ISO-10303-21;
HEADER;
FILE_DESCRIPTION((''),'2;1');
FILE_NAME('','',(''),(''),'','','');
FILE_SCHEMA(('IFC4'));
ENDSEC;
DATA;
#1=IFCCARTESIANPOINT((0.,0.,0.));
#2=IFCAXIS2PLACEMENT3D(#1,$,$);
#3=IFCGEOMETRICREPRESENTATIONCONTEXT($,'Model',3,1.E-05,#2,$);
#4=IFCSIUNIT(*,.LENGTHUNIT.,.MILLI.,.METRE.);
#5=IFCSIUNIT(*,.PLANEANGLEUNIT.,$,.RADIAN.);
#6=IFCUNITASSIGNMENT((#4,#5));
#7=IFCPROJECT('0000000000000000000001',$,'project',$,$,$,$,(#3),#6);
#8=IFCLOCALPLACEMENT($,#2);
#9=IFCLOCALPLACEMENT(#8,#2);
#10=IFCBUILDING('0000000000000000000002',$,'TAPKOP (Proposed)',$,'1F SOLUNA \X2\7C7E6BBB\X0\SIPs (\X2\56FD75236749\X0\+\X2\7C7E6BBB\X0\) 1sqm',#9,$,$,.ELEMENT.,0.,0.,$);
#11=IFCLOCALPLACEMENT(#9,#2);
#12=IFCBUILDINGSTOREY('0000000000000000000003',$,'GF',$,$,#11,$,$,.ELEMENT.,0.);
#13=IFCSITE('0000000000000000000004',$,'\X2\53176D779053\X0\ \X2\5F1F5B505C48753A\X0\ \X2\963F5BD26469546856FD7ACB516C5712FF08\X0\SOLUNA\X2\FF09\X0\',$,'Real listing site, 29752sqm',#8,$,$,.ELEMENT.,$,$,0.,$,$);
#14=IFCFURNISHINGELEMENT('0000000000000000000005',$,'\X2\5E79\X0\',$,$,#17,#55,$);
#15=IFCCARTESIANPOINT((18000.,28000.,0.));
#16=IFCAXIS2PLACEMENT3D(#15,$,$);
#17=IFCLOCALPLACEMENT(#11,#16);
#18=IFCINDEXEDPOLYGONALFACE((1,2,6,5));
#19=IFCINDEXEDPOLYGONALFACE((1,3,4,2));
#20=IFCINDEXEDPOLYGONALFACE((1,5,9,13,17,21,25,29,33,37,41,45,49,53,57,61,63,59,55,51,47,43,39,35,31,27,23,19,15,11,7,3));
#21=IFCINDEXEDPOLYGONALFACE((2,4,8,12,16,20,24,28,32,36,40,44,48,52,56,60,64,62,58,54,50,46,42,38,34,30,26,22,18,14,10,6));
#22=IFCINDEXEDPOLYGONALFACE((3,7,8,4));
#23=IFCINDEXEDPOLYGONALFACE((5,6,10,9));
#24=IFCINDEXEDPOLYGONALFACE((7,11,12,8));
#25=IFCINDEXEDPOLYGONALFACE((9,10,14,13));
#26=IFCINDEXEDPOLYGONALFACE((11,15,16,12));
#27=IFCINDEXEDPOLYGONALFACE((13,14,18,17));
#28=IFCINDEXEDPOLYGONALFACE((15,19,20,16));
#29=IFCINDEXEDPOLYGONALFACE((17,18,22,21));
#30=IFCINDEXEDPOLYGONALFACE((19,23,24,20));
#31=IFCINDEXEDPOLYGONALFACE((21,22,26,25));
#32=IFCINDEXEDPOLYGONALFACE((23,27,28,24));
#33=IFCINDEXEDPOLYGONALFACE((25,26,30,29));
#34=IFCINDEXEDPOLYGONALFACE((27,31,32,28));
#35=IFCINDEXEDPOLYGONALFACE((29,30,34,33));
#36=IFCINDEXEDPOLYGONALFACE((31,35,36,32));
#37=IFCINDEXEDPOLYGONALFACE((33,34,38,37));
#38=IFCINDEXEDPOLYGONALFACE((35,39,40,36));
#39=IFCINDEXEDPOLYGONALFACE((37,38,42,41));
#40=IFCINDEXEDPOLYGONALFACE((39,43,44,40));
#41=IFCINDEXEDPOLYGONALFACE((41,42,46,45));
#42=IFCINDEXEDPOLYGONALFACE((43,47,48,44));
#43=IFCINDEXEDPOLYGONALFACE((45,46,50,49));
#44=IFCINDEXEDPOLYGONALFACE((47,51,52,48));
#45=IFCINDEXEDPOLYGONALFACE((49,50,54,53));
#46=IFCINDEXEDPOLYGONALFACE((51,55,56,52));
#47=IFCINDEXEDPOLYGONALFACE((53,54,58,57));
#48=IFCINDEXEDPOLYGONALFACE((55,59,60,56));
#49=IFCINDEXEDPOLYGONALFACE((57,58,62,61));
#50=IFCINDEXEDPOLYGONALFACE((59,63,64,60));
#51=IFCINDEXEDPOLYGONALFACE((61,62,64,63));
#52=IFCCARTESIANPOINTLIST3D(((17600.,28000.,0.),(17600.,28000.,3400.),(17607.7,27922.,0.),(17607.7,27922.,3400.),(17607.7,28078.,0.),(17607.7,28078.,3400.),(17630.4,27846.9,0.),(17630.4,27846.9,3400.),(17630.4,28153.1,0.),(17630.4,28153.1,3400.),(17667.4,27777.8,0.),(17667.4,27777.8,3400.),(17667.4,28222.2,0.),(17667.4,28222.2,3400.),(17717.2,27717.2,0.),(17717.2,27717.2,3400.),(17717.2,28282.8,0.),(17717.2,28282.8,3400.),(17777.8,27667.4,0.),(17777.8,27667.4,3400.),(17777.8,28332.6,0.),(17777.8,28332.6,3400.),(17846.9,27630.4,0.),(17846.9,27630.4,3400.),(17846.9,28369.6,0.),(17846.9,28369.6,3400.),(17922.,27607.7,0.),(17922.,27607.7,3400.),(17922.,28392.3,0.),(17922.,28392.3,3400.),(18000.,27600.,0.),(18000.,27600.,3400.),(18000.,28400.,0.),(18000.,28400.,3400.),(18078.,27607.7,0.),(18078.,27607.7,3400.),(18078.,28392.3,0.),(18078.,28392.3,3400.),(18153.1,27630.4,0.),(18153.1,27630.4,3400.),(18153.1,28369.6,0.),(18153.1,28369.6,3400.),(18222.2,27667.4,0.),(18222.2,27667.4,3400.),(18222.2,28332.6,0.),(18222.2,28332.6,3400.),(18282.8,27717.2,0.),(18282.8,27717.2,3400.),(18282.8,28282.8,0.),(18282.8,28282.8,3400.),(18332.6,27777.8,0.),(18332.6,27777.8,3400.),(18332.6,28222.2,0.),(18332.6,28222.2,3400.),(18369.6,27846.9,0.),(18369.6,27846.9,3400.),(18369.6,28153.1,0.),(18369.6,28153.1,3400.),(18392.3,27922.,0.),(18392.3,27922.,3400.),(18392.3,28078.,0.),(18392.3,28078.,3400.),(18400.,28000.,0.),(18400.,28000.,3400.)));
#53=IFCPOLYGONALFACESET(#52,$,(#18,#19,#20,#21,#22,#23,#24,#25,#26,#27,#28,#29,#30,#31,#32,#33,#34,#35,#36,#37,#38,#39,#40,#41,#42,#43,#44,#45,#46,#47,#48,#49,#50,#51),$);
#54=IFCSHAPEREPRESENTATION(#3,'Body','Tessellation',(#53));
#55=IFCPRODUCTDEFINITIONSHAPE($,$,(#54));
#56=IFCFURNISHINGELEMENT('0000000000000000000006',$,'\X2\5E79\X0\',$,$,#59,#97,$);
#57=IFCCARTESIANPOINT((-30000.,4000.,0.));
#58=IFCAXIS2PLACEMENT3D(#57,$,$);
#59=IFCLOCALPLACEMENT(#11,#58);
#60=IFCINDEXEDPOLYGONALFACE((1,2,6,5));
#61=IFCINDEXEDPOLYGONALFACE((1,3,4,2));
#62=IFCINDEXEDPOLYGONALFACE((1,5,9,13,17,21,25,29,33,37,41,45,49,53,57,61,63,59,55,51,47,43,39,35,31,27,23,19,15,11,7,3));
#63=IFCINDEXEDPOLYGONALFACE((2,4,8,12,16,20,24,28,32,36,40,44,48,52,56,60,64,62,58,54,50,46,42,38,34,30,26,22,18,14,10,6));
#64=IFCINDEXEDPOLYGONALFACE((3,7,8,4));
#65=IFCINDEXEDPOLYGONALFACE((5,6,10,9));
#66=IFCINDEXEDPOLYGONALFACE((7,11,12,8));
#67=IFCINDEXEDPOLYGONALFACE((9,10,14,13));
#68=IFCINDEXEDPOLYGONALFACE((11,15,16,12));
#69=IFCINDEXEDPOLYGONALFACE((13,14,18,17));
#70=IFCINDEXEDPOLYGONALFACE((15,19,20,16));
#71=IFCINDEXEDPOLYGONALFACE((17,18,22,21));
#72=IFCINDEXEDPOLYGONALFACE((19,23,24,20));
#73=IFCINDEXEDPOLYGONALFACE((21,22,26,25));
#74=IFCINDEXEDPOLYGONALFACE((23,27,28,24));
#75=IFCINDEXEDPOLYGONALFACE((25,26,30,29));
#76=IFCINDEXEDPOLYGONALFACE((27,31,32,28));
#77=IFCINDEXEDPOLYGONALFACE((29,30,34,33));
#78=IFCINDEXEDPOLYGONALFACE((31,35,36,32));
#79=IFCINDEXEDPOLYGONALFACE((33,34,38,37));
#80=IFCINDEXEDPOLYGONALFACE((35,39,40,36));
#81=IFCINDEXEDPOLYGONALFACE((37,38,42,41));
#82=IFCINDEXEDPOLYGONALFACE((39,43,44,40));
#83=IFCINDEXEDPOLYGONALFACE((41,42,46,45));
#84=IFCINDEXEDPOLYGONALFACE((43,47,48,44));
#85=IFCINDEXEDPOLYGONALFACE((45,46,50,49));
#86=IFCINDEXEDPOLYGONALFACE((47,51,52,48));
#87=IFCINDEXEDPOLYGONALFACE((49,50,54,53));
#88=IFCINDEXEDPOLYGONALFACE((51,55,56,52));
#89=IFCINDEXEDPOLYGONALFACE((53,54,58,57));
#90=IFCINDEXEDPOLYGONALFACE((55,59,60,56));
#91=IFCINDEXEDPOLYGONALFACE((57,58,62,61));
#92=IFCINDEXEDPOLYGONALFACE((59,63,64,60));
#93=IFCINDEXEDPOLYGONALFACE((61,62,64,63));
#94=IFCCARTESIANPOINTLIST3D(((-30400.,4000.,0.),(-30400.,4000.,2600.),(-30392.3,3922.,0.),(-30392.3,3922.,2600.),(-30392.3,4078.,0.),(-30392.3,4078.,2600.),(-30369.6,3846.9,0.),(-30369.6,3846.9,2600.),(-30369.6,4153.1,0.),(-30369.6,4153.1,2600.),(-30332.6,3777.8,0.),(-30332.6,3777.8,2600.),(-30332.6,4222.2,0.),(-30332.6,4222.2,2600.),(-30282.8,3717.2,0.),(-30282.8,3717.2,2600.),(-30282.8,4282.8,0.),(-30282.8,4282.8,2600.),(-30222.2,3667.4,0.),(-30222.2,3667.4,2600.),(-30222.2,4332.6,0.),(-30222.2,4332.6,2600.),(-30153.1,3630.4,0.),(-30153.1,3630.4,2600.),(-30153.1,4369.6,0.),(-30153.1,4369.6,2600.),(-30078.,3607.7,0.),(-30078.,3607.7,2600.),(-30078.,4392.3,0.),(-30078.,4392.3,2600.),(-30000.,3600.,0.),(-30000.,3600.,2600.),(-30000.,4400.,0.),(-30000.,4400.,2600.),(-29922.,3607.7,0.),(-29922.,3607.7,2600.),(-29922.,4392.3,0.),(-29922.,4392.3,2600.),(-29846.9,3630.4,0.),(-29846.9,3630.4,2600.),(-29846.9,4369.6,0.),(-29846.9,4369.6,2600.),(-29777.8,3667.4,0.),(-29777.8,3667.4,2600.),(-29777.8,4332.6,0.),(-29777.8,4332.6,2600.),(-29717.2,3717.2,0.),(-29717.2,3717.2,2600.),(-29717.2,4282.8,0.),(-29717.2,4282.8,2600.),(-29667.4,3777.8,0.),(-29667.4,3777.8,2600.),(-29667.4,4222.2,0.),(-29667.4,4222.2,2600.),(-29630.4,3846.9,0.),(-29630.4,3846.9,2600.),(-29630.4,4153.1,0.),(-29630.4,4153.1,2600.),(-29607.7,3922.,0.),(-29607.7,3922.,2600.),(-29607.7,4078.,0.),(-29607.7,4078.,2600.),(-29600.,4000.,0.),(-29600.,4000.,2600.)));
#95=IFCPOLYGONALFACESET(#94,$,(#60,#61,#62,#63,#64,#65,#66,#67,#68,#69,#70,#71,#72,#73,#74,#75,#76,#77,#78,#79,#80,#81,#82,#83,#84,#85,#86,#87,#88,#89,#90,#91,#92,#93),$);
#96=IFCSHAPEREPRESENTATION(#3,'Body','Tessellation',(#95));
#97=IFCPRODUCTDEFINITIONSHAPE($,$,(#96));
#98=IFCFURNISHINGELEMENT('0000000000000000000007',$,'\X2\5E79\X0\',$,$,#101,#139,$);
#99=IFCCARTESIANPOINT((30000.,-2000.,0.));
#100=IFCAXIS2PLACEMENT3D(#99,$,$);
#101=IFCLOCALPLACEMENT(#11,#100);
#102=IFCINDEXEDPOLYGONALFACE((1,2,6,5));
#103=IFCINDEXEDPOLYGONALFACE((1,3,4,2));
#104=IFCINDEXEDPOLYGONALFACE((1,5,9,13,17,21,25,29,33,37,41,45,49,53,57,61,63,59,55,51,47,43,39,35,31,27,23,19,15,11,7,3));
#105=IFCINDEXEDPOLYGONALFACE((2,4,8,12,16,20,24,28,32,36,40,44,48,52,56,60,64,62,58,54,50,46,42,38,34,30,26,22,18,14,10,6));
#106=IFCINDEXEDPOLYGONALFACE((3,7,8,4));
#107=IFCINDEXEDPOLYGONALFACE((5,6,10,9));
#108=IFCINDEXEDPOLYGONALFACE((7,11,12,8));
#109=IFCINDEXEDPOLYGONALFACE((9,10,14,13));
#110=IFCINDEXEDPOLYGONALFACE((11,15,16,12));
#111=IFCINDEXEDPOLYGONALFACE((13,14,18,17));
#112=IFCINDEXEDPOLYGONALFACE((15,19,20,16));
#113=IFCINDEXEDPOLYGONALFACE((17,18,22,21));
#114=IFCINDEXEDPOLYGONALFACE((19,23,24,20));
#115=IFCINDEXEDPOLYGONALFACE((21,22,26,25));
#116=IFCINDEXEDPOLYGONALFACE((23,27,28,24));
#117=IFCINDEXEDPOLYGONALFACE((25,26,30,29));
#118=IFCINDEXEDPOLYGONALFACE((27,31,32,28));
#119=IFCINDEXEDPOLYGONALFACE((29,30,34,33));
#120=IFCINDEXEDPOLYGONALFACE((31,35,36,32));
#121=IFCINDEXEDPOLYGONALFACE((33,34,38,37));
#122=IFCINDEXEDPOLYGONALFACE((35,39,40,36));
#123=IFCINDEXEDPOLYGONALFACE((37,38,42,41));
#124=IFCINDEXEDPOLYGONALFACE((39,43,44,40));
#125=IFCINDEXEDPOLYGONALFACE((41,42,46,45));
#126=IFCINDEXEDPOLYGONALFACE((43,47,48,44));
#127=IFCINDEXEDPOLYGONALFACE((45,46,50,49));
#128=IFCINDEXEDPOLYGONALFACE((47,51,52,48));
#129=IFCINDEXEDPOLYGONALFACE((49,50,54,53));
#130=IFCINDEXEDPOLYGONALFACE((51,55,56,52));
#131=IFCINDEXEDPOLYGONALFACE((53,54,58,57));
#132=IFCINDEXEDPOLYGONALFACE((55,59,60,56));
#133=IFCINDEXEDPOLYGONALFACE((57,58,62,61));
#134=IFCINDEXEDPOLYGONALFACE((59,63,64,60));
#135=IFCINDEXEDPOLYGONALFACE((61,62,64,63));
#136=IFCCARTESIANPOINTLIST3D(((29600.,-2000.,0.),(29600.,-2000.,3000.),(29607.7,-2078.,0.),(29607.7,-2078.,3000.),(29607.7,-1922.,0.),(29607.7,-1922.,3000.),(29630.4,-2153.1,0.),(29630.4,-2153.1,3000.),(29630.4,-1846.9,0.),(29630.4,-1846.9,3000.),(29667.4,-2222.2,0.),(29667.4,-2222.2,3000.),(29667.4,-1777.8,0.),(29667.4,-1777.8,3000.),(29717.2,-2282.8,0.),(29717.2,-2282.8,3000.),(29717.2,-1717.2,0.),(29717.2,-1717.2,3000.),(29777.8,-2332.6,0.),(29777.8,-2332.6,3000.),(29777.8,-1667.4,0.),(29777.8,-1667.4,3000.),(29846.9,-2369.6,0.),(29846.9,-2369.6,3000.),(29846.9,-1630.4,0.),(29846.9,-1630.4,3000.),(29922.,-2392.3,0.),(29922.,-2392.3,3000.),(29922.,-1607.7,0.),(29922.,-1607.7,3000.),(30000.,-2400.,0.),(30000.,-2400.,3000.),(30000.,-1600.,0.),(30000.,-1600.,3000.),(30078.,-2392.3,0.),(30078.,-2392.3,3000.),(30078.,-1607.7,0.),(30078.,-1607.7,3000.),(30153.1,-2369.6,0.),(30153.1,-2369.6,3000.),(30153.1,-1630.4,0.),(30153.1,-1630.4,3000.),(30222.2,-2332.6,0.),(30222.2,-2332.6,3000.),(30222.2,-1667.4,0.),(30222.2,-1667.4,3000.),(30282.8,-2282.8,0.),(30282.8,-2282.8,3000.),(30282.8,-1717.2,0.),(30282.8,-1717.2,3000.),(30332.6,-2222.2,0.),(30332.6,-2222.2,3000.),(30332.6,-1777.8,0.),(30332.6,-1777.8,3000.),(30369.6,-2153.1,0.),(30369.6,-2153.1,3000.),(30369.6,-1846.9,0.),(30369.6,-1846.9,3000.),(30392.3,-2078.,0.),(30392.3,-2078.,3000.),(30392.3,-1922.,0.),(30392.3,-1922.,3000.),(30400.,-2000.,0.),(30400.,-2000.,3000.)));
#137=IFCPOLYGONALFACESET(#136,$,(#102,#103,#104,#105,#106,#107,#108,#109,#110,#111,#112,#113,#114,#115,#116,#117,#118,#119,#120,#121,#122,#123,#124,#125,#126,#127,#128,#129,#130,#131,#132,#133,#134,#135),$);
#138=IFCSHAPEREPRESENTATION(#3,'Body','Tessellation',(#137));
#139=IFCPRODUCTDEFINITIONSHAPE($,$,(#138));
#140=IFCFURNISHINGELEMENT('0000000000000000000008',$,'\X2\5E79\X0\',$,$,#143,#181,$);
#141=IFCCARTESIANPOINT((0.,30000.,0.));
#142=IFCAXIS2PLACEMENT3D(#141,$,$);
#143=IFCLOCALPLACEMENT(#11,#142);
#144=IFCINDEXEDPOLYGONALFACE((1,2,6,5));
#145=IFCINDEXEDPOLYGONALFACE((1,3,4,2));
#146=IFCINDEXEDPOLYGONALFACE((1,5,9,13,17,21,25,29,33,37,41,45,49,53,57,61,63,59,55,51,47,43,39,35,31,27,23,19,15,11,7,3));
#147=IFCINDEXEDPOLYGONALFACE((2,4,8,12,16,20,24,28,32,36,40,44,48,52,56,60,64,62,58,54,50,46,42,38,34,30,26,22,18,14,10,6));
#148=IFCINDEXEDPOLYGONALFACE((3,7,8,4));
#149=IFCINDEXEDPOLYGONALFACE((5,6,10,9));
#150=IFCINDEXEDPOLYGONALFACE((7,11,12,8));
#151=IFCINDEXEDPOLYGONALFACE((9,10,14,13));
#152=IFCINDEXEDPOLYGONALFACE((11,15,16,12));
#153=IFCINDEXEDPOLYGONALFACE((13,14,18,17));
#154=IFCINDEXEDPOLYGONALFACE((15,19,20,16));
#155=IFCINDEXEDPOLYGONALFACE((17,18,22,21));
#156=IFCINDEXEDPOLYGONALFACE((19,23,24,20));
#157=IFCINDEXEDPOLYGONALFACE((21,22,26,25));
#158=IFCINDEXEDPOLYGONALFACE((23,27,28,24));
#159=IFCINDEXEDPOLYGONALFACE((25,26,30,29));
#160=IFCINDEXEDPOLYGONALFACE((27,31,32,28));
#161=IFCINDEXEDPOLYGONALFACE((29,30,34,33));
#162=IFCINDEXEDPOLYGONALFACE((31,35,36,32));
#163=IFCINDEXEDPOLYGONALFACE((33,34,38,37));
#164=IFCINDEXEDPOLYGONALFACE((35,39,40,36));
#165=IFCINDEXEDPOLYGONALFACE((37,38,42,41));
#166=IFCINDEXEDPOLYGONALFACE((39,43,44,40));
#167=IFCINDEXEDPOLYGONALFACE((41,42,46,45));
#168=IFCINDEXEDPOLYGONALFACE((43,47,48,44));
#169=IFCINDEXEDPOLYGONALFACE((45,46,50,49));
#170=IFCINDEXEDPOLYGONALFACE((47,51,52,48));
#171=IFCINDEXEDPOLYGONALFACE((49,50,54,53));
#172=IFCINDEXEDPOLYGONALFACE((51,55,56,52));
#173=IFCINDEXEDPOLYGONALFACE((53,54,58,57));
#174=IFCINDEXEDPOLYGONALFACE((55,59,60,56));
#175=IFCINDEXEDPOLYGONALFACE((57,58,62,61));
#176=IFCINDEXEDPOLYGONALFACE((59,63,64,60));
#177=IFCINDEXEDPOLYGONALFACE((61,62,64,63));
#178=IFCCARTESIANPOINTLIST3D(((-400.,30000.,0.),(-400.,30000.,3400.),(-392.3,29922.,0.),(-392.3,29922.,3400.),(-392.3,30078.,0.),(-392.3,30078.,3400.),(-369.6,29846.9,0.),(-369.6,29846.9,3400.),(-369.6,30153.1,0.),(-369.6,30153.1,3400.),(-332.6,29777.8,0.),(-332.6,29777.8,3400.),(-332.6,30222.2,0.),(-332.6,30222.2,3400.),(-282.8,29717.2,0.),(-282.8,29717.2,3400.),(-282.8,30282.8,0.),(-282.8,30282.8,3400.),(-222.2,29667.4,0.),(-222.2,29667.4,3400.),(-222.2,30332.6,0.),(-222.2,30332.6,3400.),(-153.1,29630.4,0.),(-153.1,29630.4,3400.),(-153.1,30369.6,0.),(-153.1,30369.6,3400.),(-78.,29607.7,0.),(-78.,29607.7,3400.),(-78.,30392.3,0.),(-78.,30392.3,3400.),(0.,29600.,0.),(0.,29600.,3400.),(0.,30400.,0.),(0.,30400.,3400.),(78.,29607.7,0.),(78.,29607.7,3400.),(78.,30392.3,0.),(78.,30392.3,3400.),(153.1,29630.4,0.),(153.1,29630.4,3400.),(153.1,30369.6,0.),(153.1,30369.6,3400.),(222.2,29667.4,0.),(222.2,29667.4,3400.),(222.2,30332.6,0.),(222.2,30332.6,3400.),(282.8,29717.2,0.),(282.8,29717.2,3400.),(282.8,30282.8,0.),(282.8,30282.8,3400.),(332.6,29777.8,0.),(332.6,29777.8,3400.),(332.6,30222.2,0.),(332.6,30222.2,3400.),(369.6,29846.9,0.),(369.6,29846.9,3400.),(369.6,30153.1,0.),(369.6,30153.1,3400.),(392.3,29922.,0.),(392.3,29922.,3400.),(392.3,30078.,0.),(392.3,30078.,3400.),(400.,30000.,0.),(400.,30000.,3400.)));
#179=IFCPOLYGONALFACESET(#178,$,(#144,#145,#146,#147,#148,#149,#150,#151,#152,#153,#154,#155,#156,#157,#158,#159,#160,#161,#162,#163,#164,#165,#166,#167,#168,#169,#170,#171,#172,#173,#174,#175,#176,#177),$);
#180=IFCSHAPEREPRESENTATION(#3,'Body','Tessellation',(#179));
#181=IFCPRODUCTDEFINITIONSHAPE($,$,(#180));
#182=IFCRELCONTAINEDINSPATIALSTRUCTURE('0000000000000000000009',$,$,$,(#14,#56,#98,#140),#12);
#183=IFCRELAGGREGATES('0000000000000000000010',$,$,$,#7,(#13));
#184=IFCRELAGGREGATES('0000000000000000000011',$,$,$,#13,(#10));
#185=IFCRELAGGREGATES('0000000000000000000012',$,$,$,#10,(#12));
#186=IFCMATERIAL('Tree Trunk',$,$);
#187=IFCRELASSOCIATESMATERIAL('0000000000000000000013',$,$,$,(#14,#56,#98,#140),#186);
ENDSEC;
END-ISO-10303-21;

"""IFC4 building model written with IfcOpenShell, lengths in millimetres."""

from ifc_helpers import new_model, si_unit, frame, origin, origin_2d, place, context, project, spatial, circle, extrude, material, element, save


model = new_model("IFC4")

# Units and contexts
model_context = context("Model", 3, precision=1e-05, world=origin())
ifc_project = project(units=[si_unit("LENGTHUNIT", "METRE", prefix="MILLI"), si_unit("PLANEANGLEUNIT", "RADIAN")], contexts=[model_context])

# Site, building, storey
site_placement = place(None, origin())
site = spatial("IfcSite", under=ifc_project, at=site_placement, Name="北海道 弟子屈町 阿寒摩周国立公園（SOLUNA）", ObjectType="Real listing site, 29752sqm", CompositionType="ELEMENT", RefElevation=0.0)
building_placement = place(site_placement, origin())
building = spatial("IfcBuilding", under=site, at=building_placement, Name="TAPKOP (Proposed)", ObjectType="1F SOLUNA 籾殻SIPs (国産杉+籾殻) 1sqm", CompositionType="ELEMENT", ElevationOfRefHeight=0.0, ElevationOfTerrain=0.0)
storey_placement = place(building_placement, origin())
storey = spatial("IfcBuildingStorey", under=building, at=storey_placement, Name="GF", CompositionType="ELEMENT", Elevation=0.0)

# Furnishing elements
ifc_material_1 = material(Name="Tree Trunk")
furnishing_1_placement = place(storey_placement, frame((18000.0, 28000.0, 0.0)))
element("IfcFurnishingElement", 1, at=furnishing_1_placement, inside=storey, material=ifc_material_1, Name="幹", context=model_context, shape_type="SweptSolid", body=[
    extrude(circle(Radius=400.0, at=origin_2d()), frame((18000.0, 28000.0, 0.0)), (0.0, 0.0, 1.0), 3400.0),
])
furnishing_2_placement = place(storey_placement, frame((-30000.0, 4000.0, 0.0)))
element("IfcFurnishingElement", 2, at=furnishing_2_placement, inside=storey, material=ifc_material_1, Name="幹", context=model_context, shape_type="SweptSolid", body=[
    extrude(circle(Radius=400.0, at=origin_2d()), frame((-30000.0, 4000.0, 0.0)), (0.0, 0.0, 1.0), 2600.0),
])
furnishing_3_placement = place(storey_placement, frame((30000.0, -2000.0, 0.0)))
element("IfcFurnishingElement", 3, at=furnishing_3_placement, inside=storey, material=ifc_material_1, Name="幹", context=model_context, shape_type="SweptSolid", body=[
    extrude(circle(Radius=400.0, at=origin_2d()), frame((30000.0, -2000.0, 0.0)), (0.0, 0.0, 1.0), 3000.0),
])
furnishing_4_placement = place(storey_placement, frame((0.0, 30000.0, 0.0)))
element("IfcFurnishingElement", 4, at=furnishing_4_placement, inside=storey, material=ifc_material_1, Name="幹", context=model_context, shape_type="SweptSolid", body=[
    extrude(circle(Radius=400.0, at=origin_2d()), frame((0.0, 30000.0, 0.0)), (0.0, 0.0, 1.0), 3400.0),
])

save(model, "model.ifc")
